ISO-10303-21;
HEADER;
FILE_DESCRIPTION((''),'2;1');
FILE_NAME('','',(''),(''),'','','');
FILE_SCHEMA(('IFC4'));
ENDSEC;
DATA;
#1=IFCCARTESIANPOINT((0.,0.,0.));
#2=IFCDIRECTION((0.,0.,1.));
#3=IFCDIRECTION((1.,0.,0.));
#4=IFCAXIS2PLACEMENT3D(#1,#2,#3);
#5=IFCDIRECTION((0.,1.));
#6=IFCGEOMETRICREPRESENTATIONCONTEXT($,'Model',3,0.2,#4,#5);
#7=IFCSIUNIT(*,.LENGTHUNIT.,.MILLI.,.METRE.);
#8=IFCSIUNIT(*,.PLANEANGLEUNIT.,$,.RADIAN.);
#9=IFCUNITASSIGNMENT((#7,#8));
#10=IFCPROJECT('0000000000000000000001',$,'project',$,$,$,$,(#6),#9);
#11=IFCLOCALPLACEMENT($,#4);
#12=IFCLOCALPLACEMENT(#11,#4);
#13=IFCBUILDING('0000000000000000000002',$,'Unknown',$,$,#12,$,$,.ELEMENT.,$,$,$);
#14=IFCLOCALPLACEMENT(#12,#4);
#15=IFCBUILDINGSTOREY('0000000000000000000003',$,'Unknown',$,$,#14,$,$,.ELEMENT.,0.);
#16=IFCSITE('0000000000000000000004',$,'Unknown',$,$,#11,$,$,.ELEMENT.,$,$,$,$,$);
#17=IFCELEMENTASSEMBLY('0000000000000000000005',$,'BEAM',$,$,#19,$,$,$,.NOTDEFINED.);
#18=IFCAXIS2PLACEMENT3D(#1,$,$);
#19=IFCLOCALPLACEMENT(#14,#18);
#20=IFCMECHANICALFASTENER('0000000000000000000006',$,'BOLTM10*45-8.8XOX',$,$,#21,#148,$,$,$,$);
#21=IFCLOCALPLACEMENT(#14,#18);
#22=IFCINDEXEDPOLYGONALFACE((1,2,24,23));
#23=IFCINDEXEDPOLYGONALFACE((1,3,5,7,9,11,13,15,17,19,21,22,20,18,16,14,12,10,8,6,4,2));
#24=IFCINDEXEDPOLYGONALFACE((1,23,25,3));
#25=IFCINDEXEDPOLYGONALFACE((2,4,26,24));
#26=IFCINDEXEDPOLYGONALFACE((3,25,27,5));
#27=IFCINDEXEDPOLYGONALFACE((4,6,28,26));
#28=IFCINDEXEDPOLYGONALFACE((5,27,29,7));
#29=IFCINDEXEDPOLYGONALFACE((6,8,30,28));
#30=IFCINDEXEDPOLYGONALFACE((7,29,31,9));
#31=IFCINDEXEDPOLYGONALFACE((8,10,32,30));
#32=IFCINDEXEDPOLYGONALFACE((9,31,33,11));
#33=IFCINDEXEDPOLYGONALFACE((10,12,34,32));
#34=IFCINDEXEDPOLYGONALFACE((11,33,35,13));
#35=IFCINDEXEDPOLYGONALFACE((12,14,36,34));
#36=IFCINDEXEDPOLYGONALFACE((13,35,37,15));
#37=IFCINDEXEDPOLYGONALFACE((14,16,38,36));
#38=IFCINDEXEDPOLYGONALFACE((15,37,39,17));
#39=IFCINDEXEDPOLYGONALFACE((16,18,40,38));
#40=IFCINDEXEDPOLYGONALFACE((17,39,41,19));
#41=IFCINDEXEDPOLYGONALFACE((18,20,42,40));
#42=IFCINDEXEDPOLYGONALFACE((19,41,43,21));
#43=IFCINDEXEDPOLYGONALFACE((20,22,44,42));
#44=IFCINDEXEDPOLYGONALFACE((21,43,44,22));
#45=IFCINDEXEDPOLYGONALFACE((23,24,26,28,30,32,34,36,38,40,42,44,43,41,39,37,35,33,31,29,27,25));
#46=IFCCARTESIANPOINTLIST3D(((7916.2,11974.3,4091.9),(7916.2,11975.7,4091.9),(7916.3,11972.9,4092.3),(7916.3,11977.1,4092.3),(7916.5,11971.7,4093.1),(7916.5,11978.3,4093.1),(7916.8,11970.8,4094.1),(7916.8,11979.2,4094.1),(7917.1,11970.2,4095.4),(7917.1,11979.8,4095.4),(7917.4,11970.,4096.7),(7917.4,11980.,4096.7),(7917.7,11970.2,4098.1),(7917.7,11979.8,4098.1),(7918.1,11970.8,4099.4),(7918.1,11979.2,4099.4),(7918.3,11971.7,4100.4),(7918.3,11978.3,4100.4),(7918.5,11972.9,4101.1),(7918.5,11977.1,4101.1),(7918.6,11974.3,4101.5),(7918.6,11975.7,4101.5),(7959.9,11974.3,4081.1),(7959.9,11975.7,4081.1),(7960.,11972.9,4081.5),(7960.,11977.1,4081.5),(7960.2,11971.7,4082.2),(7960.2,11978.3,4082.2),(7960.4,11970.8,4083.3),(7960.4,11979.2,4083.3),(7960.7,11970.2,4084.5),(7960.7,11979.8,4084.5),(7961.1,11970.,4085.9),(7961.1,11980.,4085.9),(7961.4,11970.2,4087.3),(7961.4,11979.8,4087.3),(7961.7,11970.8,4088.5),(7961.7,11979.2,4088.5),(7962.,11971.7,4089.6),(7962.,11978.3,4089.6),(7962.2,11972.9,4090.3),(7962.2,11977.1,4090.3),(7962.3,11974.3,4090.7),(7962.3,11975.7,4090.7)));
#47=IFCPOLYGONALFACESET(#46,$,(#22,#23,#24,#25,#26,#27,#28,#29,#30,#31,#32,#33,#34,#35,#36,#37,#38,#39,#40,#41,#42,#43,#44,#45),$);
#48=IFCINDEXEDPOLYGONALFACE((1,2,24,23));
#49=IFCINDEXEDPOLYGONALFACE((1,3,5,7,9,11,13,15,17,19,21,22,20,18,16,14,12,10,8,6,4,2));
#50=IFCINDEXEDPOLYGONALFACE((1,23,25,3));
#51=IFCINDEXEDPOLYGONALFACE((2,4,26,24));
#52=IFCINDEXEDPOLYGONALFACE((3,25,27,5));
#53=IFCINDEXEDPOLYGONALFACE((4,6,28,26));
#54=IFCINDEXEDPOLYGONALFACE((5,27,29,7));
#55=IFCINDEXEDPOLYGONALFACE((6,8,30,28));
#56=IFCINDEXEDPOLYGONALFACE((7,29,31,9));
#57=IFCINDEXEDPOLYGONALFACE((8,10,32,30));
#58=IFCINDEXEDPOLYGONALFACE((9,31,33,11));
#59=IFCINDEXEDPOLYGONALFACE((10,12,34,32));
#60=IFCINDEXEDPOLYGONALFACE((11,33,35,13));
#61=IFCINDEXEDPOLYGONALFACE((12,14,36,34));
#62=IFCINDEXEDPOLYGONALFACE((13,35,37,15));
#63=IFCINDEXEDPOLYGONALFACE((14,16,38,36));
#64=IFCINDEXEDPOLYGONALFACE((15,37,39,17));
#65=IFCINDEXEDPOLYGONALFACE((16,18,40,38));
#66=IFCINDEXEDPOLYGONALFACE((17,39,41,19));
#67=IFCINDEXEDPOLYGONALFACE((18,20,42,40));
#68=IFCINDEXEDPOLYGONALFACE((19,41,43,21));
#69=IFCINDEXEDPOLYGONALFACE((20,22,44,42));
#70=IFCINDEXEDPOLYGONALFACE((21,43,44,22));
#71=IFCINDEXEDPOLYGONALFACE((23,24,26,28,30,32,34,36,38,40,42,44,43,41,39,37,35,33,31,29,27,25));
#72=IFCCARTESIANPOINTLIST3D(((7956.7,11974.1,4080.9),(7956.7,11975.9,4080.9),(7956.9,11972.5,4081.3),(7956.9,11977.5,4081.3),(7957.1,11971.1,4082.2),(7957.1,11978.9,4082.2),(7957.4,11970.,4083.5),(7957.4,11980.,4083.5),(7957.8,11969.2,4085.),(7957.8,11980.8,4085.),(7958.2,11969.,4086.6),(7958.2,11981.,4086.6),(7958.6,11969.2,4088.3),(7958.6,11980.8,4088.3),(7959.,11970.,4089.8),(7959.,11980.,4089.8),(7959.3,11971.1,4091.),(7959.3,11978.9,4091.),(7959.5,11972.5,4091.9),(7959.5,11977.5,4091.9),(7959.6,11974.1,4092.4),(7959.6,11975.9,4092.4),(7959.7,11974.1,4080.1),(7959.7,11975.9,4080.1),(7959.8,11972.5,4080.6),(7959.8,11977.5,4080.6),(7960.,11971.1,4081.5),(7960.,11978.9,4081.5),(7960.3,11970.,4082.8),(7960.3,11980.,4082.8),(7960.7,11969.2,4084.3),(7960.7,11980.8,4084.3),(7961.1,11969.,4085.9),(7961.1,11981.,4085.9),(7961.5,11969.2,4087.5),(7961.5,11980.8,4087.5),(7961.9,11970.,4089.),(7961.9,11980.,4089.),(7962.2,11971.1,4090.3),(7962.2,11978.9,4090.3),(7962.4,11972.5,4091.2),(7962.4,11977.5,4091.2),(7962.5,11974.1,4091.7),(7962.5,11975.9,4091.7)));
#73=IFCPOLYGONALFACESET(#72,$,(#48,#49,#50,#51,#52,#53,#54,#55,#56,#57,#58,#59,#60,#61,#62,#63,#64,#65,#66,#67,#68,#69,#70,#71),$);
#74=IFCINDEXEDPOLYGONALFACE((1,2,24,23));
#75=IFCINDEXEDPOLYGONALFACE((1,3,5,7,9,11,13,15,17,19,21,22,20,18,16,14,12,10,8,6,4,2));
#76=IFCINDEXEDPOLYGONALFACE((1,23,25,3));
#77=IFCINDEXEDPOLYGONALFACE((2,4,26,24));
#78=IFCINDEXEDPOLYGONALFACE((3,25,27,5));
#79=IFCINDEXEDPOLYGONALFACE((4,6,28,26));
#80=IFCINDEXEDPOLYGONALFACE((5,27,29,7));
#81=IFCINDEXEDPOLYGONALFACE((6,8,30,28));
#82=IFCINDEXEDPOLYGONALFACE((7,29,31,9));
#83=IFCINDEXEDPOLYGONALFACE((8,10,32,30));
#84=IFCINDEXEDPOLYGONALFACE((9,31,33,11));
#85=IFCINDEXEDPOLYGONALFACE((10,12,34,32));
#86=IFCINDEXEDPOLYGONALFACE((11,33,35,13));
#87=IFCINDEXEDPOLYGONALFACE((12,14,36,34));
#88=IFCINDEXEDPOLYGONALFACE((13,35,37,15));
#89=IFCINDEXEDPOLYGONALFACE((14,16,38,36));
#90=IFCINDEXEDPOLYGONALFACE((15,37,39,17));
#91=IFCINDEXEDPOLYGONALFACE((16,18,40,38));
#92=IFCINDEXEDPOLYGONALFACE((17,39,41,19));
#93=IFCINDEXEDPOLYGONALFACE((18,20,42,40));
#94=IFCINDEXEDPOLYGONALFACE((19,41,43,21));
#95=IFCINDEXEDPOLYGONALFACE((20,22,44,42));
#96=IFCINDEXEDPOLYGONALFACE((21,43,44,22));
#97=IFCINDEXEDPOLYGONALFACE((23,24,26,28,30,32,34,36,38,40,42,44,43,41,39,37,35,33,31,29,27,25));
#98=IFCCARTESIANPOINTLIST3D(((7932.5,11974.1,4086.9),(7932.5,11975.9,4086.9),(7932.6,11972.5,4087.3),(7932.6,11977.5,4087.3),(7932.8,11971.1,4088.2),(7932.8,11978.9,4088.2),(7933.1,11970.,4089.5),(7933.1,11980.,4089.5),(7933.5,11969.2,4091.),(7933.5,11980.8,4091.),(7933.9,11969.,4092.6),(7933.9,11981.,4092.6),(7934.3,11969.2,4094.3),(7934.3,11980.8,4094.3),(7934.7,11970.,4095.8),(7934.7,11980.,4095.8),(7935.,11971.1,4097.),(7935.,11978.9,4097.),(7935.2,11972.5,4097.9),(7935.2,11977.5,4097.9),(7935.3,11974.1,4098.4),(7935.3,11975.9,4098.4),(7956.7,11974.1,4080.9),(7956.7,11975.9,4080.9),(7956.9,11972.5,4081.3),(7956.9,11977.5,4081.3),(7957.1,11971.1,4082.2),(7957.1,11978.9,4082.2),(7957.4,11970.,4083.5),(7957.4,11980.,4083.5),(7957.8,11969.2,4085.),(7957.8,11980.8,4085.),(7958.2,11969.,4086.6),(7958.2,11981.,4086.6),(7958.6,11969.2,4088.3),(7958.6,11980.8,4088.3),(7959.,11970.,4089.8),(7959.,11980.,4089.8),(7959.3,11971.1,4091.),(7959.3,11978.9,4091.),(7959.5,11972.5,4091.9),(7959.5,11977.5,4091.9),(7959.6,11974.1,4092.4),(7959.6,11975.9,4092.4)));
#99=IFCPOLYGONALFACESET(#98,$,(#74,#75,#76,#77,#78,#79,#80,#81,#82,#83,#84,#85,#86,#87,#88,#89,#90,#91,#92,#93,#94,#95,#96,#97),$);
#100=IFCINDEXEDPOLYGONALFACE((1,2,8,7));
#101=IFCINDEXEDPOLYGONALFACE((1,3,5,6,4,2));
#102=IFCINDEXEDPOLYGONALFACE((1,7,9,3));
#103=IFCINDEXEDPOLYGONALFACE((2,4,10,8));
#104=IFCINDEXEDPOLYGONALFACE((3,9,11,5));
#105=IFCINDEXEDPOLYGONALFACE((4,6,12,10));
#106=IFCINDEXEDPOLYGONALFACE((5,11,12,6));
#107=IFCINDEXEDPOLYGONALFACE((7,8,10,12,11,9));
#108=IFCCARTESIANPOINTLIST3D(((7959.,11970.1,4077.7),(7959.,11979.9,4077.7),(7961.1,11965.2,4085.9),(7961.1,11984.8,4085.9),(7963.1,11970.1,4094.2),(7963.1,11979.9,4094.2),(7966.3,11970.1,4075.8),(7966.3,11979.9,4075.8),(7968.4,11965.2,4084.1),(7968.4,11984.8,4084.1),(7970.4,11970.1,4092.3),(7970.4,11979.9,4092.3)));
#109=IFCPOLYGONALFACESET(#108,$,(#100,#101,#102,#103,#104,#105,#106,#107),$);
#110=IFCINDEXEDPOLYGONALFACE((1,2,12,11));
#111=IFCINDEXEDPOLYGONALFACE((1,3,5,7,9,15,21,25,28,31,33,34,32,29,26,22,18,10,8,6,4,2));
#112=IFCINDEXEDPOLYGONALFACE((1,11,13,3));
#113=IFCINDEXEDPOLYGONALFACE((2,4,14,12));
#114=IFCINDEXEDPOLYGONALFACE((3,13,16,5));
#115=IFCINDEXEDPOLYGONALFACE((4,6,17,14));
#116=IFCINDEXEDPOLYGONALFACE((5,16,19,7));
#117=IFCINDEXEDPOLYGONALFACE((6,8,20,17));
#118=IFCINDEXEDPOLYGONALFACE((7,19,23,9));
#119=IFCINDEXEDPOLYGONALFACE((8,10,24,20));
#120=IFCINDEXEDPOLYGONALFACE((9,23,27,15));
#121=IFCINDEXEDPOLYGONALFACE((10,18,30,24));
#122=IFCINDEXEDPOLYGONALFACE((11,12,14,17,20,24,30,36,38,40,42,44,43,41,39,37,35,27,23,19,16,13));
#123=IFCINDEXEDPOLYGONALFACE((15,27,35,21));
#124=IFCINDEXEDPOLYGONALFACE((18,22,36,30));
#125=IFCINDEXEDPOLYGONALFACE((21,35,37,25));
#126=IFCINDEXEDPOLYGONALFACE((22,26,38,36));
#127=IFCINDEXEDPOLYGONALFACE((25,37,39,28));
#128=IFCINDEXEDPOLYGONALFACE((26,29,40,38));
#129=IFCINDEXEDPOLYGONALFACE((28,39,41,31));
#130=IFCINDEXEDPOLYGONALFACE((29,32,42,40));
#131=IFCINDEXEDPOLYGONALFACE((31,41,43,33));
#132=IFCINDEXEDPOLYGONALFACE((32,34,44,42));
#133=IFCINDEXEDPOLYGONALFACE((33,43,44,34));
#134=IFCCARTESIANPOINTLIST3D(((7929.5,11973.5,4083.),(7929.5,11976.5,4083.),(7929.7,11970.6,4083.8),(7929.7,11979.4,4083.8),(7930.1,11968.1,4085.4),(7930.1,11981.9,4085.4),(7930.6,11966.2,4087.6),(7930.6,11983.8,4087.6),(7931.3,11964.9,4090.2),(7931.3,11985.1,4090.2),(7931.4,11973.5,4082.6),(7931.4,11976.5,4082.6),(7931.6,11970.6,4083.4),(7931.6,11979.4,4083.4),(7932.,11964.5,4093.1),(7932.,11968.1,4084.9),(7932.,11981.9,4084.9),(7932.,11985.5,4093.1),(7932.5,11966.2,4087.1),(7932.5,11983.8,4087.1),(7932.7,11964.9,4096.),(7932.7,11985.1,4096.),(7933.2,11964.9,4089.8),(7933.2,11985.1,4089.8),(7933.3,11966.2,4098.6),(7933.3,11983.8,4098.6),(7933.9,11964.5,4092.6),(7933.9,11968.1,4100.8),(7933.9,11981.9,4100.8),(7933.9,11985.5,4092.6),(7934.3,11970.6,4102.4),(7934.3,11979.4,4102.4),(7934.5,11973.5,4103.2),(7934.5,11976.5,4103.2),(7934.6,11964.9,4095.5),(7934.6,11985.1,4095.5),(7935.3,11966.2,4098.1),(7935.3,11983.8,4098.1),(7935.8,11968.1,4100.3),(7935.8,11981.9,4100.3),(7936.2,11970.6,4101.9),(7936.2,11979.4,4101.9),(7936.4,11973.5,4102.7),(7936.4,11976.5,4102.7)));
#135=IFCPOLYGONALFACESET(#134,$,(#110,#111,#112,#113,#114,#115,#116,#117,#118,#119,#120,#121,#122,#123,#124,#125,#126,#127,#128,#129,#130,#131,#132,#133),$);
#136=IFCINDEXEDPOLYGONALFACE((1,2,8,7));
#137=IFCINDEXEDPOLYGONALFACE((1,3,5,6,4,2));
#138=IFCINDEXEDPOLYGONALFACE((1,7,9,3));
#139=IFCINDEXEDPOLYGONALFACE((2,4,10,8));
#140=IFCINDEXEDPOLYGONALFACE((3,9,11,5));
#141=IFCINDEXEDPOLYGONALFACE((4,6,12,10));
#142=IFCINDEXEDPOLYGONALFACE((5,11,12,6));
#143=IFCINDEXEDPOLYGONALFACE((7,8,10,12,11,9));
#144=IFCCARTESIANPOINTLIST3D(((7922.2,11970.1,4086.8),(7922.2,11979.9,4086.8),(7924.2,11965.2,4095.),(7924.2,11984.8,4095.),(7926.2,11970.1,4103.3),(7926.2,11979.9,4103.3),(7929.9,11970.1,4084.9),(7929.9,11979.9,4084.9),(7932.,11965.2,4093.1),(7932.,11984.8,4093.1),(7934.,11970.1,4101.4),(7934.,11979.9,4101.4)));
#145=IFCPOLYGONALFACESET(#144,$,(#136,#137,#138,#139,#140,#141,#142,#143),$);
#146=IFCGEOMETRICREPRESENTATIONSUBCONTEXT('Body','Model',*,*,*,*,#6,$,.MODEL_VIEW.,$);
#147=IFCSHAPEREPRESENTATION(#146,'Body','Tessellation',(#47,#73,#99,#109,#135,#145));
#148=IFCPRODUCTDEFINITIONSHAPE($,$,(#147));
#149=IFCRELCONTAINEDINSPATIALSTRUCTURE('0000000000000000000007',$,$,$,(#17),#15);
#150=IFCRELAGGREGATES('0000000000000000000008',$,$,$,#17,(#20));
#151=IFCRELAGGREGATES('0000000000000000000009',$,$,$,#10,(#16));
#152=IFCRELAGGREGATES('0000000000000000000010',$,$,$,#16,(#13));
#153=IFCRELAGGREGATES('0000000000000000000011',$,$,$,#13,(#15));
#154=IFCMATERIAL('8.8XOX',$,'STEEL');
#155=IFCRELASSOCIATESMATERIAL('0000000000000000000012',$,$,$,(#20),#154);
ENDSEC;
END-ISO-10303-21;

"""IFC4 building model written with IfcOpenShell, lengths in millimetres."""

from ifc_helpers import new_model, si_unit, direction, frame, origin_with_axes, place, context, subcontext, project, spatial, line, arc, indexed_curve, outline, extrude, source, transform, mapped, material, element, aggregate, save


model = new_model("IFC4")

# Units and contexts
model_context = context("Model", 3, precision=0.2, world=origin_with_axes(), true_north=direction((0.0, 1.0)))
body_context = subcontext(model_context, "Body", "Model", "MODEL_VIEW")
ifc_project = project(units=[si_unit("LENGTHUNIT", "METRE", prefix="MILLI"), si_unit("PLANEANGLEUNIT", "RADIAN")], contexts=[model_context])

# Site, building, storey
site_placement = place(None, origin_with_axes())
site = spatial("IfcSite", under=ifc_project, at=site_placement, Name="Unknown", CompositionType="ELEMENT")
building_placement = place(site_placement, origin_with_axes())
building = spatial("IfcBuilding", under=site, at=building_placement, Name="Unknown", CompositionType="ELEMENT")
storey_placement = place(building_placement, origin_with_axes())
storey = spatial("IfcBuildingStorey", under=building, at=storey_placement, Name="Unknown", CompositionType="ELEMENT", Elevation=0.0)

# Shared definitions
ifc_material_1 = material(Name="8.8XOX", Category="STEEL")

# Element assembly, mechanical fastener
shared_shape_1 = source(origin_with_axes(), body_context, "Body", "SweptSolid", [
    extrude(outline(indexed_curve([(5.0, 0.0), (0.0, 5.0), (-5.0, 0.0), (0.0, -5.0)], segments=[arc(1, 2, 3), arc(3, 4, 1)])), frame((0.0, 0.0, 3.8), z_axis=(0.0, 0.0, -1.0), x_axis=(0.0, 1.0, 0.0)), (0.0, 0.0, 1.0), 45.0),
    extrude(outline(indexed_curve([(6.0, 0.0), (0.0, 6.0), (-6.0, 0.0), (0.0, -6.0)], segments=[arc(1, 2, 3), arc(3, 4, 1)])), frame((0.0, 0.0, 3.8), z_axis=(0.0, 0.0, -1.0), x_axis=(0.0, 1.0, 0.0)), (0.0, 0.0, 1.0), 3.0),
    extrude(outline(indexed_curve([(6.0, 0.0), (0.0, 6.0), (-6.0, 0.0), (0.0, -6.0)], segments=[arc(1, 2, 3), arc(3, 4, 1)])), frame((0.0, 0.0, 0.8), z_axis=(0.0, 0.0, -1.0), x_axis=(0.0, 1.0, 0.0)), (0.0, 0.0, 1.0), 25.0),
    extrude(outline(indexed_curve([(9.8, 0.0), (4.9, 8.5), (-4.9, 8.5), (-9.8, 0.0), (-4.9, -8.5), (4.9, -8.5)], segments=[line(1, 2, 3, 4, 5, 6, 1)])), frame((0.0, 0.0, 11.2), z_axis=(0.0, 0.0, -1.0), x_axis=(0.0, 1.0, 0.0)), (0.0, 0.0, 1.0), 7.5),
    extrude(outline(indexed_curve([(10.5, 0.0), (0.0, 10.5), (-10.5, 0.0), (0.0, -10.5)], segments=[arc(1, 2, 3), arc(3, 4, 1)])), frame((0.0, 0.0, -24.2), z_axis=(0.0, 0.0, -1.0), x_axis=(0.0, 1.0, 0.0)), (0.0, 0.0, 1.0), 2.0),
    extrude(outline(indexed_curve([(9.8, 0.0), (4.9, 8.5), (-4.9, 8.5), (-9.8, 0.0), (-4.9, -8.5), (4.9, -8.5)], segments=[line(1, 2, 3, 4, 5, 6, 1)])), frame((0.0, 0.0, -26.2), z_axis=(0.0, 0.0, -1.0), x_axis=(0.0, 1.0, 0.0)), (0.0, 0.0, 1.0), 8.0),
])
assembly_1_placement = place(storey_placement, frame((7947.2, 6000.0, 4094.5), z_axis=(0.970613, 0.0, -0.240648), x_axis=(0.0, 1.0, 0.0)))
assembly_1 = element("IfcElementAssembly", 1, at=assembly_1_placement, inside=storey, Name="BEAM", PredefinedType="NOTDEFINED")
mechanical_fastener_1_placement = place(assembly_1_placement, frame((5975.0, -5.0, 11.8), z_axis=(0.0, 0.0, 1.0), x_axis=(0.0, 1.0, 0.0)))
mechanical_fastener_1 = element("IfcMechanicalFastener", 2, at=mechanical_fastener_1_placement, material=ifc_material_1, Name="BOLTM10*45-8.8XOX", context=body_context, shape_type="MappedRepresentation", body=[
    mapped(shared_shape_1, transform((0.0, 0.0, 0.0))),
])
aggregate(assembly_1, [mechanical_fastener_1])

save(model, "model.ifc")
